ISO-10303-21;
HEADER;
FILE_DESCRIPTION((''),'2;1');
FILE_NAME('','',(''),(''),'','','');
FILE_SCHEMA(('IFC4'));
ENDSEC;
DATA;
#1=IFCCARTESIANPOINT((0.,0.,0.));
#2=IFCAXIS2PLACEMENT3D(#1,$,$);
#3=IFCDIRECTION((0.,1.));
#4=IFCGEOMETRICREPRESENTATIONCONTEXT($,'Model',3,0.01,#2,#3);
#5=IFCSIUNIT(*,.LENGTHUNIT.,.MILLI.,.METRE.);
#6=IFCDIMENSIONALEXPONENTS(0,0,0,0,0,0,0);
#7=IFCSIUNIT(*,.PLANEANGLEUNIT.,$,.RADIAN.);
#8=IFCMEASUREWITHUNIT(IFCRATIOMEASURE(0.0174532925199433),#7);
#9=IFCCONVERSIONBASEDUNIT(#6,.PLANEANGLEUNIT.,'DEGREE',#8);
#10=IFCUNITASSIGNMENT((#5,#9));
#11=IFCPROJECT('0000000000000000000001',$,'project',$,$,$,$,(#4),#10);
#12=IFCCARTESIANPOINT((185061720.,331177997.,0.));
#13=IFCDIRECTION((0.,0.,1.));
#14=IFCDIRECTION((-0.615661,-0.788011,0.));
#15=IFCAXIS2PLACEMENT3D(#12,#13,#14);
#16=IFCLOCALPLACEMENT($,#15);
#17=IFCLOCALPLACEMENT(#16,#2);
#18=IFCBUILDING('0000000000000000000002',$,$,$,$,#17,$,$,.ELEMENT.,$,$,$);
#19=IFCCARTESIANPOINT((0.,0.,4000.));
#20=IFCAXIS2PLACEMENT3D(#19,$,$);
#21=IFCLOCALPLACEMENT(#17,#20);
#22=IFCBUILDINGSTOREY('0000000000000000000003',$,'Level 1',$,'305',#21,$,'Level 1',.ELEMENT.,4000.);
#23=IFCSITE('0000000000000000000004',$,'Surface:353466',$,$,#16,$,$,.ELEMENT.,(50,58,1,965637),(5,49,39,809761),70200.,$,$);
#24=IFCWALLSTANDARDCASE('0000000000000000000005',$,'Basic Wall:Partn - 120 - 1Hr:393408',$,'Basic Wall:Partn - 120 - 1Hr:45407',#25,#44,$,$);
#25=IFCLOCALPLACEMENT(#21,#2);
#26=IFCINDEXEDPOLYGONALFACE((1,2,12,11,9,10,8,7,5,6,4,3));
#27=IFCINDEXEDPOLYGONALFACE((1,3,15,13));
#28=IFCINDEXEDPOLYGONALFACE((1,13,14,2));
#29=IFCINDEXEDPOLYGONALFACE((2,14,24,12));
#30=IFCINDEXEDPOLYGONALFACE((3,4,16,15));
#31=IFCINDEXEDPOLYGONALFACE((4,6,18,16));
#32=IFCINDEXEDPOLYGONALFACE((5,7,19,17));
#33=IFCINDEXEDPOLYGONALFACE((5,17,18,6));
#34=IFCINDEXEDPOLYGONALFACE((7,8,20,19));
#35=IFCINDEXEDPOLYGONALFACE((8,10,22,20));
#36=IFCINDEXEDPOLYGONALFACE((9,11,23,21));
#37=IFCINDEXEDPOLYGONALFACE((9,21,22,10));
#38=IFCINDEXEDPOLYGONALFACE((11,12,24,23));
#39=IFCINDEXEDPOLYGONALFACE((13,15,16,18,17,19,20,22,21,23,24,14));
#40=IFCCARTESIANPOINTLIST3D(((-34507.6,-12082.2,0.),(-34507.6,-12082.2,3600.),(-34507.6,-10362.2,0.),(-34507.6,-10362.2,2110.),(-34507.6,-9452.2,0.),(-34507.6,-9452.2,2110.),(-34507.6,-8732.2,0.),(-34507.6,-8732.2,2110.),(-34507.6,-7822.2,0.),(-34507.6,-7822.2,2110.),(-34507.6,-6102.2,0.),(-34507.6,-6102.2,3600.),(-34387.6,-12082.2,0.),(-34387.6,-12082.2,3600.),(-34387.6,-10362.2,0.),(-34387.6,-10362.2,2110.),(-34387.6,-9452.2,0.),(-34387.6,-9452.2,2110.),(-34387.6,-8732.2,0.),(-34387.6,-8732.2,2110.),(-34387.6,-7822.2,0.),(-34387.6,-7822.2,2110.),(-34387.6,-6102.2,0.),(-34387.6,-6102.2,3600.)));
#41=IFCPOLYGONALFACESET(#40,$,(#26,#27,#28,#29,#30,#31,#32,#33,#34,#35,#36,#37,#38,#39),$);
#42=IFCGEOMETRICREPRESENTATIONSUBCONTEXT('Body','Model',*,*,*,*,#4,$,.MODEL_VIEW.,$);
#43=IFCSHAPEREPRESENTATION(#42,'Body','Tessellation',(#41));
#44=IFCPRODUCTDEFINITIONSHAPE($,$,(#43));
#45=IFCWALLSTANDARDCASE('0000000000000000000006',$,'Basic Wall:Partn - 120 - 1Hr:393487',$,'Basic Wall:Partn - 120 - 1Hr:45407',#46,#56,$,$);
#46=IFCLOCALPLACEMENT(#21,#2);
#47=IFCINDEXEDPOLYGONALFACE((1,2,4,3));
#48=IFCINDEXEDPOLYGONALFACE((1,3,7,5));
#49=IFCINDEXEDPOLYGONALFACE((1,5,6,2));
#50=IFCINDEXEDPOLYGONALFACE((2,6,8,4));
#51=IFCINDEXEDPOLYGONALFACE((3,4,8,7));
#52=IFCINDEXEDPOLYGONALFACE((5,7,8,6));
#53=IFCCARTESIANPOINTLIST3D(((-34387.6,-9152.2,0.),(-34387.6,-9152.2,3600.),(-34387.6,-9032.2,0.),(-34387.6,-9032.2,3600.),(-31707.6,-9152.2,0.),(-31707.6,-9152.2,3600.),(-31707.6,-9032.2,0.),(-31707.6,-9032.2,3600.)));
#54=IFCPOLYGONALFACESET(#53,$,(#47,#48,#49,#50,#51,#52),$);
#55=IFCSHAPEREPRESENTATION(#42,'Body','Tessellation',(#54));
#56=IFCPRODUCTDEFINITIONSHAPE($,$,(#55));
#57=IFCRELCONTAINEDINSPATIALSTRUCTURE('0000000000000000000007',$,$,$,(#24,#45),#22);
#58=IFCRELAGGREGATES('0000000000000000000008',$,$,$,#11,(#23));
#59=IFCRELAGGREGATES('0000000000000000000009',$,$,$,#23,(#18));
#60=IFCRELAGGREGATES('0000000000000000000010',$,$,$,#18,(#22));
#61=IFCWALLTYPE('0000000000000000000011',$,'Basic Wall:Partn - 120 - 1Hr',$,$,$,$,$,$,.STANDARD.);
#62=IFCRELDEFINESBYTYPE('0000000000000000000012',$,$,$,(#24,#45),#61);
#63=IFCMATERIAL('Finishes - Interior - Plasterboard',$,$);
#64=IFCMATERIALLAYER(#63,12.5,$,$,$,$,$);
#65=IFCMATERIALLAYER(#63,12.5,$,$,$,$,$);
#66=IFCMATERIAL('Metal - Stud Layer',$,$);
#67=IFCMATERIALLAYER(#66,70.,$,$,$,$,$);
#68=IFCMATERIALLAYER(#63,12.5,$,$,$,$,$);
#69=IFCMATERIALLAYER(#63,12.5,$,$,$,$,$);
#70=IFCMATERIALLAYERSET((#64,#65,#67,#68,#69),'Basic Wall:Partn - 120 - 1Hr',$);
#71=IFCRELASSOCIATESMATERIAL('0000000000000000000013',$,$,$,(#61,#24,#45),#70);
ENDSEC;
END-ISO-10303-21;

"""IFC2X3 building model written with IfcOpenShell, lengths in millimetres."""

from ifc_helpers import new_model, entity, si_unit, converted_unit, direction, frame, frame_2d, origin, place, context, subcontext, project, spatial, polyline, rectangle, extrude, clip, bounded_halfspace, material, layer, layer_set, layer_usage, type_object, element, save


model = new_model("IFC2X3")

# Units and contexts
model_context = context("Model", 3, precision=0.01, world=origin(), true_north=direction((0.0, 1.0)))
body_context = subcontext(model_context, "Body", "Model", "MODEL_VIEW")
ifc_project = project(units=[si_unit("LENGTHUNIT", "METRE", prefix="MILLI"), converted_unit("PLANEANGLEUNIT", "DEGREE", entity("IfcRatioMeasure", 0.0174532925199433), si_unit("PLANEANGLEUNIT", "RADIAN"), dimensions=[0, 0, 0, 0, 0, 0, 0])], contexts=[model_context])

# Site, building, storey
site_placement = place(None, frame((185061720.0, 331177997.0, 0.0), z_axis=(0.0, 0.0, 1.0), x_axis=(-0.615661, -0.788011, 0.0)))
site = spatial("IfcSite", under=ifc_project, at=site_placement, Name="Surface:353466", CompositionType="ELEMENT", RefLatitude=(50, 58, 1, 965637), RefLongitude=(5, 49, 39, 809761), RefElevation=70200.0)
building_placement = place(site_placement, origin())
building = spatial("IfcBuilding", under=site, at=building_placement, CompositionType="ELEMENT")
storey_placement = place(building_placement, frame((0.0, 0.0, 4000.0)))
storey = spatial("IfcBuildingStorey", under=building, at=storey_placement, Name="Level 1", ObjectType="305", LongName="Level 1", CompositionType="ELEMENT", Elevation=4000.0)

# Shared definitions
ifc_material_1 = material(Name="Finishes - Interior - Plasterboard")

# Shared definitions
ifc_material_2 = material(Name="Metal - Stud Layer")

# Shared definitions
ifc_layer_1 = layer(ifc_material_1, 12.5)
ifc_layer_2 = layer(ifc_material_1, 12.5)
ifc_layer_3 = layer(ifc_material_2, 70.0)
ifc_layer_4 = layer(ifc_material_1, 12.5)
ifc_layer_5 = layer(ifc_material_1, 12.5)
ifc_layer_set_1 = layer_set([ifc_layer_1, ifc_layer_2, ifc_layer_3, ifc_layer_4, ifc_layer_5], Name="Basic Wall:Partn - 120 - 1Hr")
wall_type_1 = type_object("IfcWallType", Name="Basic Wall:Partn - 120 - 1Hr", PredefinedType="STANDARD", material=ifc_layer_set_1)

# Wall, openings
ifc_layer_usage_1 = layer_usage(ifc_layer_set_1, "AXIS2", "NEGATIVE", 60.0)
wall_1_placement = place(storey_placement, frame((-34447.6, -12082.2, 0.0), z_axis=(0.0, 0.0, 1.0), x_axis=(0.0, 1.0, 0.0)))
wall_1 = element("IfcWallStandardCase", 1, at=wall_1_placement, inside=storey, type_object=wall_type_1, material=ifc_layer_usage_1, Name="Basic Wall:Partn - 120 - 1Hr:393408", ObjectType="Basic Wall:Partn - 120 - 1Hr:45407", context=body_context, shape_type="Clipping", body=[
    clip(extrude(rectangle(XDim=5980.0, YDim=120.0, at=frame_2d((2990.0, 0.0), x_axis=(-1.0, 0.0))), origin(), (0.0, 0.0, 1.0), 3600.0), bounded_halfspace(frame((0.0, -60.0, 3600.0), z_axis=(0.0, 0.0, -1.0), x_axis=(0.0, -1.0, 0.0)), True, frame((0.0, -60.0, 3600.0)), polyline([(0.0, 0.0), (2930.0, 0.0), (3050.0, 0.0), (5980.0, 0.0), (5980.0, 120.0), (0.0, 120.0), (0.0, 0.0)]))),
])
opening_1_placement = place(wall_1_placement, origin())
element("IfcOpeningElement", 2, at=opening_1_placement, cuts=wall_1, ObjectType="Opening", context=body_context, shape_type="SweptSolid", body=[
    extrude(rectangle(XDim=2110.0, YDim=910.0, at=frame_2d((0.0, 0.0), x_axis=(1.0, 0.0))), frame((3805.0, -1464.0, 1055.0), z_axis=(0.0, 1.0, 0.0), x_axis=(0.0, 0.0, 1.0)), (0.0, 0.0, 1.0), 3048.0),
])
opening_2_placement = place(wall_1_placement, origin())
element("IfcOpeningElement", 3, at=opening_2_placement, cuts=wall_1, ObjectType="Opening", context=body_context, shape_type="SweptSolid", body=[
    extrude(rectangle(XDim=2110.0, YDim=910.0, at=frame_2d((0.0, 0.0), x_axis=(0.0, 1.0))), frame((2175.0, -1464.0, 1055.0), z_axis=(0.0, 1.0, 0.0), x_axis=(-1.0, 0.0, 0.0)), (0.0, 0.0, 1.0), 3048.0),
])
opening_3_placement = place(wall_1_placement, frame((4260.0, 60.0, 0.0)))
element("IfcOpeningElement", 4, at=opening_3_placement, cuts=wall_1, ObjectType="Opening", context=body_context, shape_type="SweptSolid", body=[
    extrude(rectangle(XDim=2110.0, YDim=910.0, at=frame_2d((1055.0, 455.0), x_axis=(1.0, 0.0))), frame((0.0, 0.0, 0.0), z_axis=(0.0, -1.0, 0.0), x_axis=(0.0, 0.0, 1.0)), (0.0, 0.0, 1.0), 120.0),
])
opening_4_placement = place(wall_1_placement, frame((2630.0, 60.0, 0.0)))
element("IfcOpeningElement", 5, at=opening_4_placement, cuts=wall_1, ObjectType="Opening", context=body_context, shape_type="SweptSolid", body=[
    extrude(rectangle(XDim=2110.0, YDim=910.0, at=frame_2d((1055.0, 455.0), x_axis=(1.0, 0.0))), frame((0.0, 0.0, 0.0), z_axis=(0.0, -1.0, 0.0), x_axis=(0.0, 0.0, 1.0)), (0.0, 0.0, 1.0), 120.0),
])

# Wall
ifc_layer_usage_2 = layer_usage(ifc_layer_set_1, "AXIS2", "NEGATIVE", 60.0)
wall_2_placement = place(storey_placement, frame((-34387.6, -9092.2, 0.0)))
element("IfcWallStandardCase", 6, at=wall_2_placement, inside=storey, type_object=wall_type_1, material=ifc_layer_usage_2, Name="Basic Wall:Partn - 120 - 1Hr:393487", ObjectType="Basic Wall:Partn - 120 - 1Hr:45407", context=body_context, shape_type="Clipping", body=[
    clip(extrude(rectangle(XDim=2680.0, YDim=120.0, at=frame_2d((1340.0, 0.0), x_axis=(-1.0, 0.0))), origin(), (0.0, 0.0, 1.0), 3600.0), bounded_halfspace(frame((0.0, -60.0, 3600.0), z_axis=(0.0, 0.0, -1.0), x_axis=(1.0, 0.0, 0.0)), True, frame((0.0, -60.0, 3600.0)), polyline([(0.0, 0.0), (2680.0, 0.0), (2680.0, 120.0), (0.0, 120.0), (0.0, 0.0)]))),
])

save(model, "model.ifc")
